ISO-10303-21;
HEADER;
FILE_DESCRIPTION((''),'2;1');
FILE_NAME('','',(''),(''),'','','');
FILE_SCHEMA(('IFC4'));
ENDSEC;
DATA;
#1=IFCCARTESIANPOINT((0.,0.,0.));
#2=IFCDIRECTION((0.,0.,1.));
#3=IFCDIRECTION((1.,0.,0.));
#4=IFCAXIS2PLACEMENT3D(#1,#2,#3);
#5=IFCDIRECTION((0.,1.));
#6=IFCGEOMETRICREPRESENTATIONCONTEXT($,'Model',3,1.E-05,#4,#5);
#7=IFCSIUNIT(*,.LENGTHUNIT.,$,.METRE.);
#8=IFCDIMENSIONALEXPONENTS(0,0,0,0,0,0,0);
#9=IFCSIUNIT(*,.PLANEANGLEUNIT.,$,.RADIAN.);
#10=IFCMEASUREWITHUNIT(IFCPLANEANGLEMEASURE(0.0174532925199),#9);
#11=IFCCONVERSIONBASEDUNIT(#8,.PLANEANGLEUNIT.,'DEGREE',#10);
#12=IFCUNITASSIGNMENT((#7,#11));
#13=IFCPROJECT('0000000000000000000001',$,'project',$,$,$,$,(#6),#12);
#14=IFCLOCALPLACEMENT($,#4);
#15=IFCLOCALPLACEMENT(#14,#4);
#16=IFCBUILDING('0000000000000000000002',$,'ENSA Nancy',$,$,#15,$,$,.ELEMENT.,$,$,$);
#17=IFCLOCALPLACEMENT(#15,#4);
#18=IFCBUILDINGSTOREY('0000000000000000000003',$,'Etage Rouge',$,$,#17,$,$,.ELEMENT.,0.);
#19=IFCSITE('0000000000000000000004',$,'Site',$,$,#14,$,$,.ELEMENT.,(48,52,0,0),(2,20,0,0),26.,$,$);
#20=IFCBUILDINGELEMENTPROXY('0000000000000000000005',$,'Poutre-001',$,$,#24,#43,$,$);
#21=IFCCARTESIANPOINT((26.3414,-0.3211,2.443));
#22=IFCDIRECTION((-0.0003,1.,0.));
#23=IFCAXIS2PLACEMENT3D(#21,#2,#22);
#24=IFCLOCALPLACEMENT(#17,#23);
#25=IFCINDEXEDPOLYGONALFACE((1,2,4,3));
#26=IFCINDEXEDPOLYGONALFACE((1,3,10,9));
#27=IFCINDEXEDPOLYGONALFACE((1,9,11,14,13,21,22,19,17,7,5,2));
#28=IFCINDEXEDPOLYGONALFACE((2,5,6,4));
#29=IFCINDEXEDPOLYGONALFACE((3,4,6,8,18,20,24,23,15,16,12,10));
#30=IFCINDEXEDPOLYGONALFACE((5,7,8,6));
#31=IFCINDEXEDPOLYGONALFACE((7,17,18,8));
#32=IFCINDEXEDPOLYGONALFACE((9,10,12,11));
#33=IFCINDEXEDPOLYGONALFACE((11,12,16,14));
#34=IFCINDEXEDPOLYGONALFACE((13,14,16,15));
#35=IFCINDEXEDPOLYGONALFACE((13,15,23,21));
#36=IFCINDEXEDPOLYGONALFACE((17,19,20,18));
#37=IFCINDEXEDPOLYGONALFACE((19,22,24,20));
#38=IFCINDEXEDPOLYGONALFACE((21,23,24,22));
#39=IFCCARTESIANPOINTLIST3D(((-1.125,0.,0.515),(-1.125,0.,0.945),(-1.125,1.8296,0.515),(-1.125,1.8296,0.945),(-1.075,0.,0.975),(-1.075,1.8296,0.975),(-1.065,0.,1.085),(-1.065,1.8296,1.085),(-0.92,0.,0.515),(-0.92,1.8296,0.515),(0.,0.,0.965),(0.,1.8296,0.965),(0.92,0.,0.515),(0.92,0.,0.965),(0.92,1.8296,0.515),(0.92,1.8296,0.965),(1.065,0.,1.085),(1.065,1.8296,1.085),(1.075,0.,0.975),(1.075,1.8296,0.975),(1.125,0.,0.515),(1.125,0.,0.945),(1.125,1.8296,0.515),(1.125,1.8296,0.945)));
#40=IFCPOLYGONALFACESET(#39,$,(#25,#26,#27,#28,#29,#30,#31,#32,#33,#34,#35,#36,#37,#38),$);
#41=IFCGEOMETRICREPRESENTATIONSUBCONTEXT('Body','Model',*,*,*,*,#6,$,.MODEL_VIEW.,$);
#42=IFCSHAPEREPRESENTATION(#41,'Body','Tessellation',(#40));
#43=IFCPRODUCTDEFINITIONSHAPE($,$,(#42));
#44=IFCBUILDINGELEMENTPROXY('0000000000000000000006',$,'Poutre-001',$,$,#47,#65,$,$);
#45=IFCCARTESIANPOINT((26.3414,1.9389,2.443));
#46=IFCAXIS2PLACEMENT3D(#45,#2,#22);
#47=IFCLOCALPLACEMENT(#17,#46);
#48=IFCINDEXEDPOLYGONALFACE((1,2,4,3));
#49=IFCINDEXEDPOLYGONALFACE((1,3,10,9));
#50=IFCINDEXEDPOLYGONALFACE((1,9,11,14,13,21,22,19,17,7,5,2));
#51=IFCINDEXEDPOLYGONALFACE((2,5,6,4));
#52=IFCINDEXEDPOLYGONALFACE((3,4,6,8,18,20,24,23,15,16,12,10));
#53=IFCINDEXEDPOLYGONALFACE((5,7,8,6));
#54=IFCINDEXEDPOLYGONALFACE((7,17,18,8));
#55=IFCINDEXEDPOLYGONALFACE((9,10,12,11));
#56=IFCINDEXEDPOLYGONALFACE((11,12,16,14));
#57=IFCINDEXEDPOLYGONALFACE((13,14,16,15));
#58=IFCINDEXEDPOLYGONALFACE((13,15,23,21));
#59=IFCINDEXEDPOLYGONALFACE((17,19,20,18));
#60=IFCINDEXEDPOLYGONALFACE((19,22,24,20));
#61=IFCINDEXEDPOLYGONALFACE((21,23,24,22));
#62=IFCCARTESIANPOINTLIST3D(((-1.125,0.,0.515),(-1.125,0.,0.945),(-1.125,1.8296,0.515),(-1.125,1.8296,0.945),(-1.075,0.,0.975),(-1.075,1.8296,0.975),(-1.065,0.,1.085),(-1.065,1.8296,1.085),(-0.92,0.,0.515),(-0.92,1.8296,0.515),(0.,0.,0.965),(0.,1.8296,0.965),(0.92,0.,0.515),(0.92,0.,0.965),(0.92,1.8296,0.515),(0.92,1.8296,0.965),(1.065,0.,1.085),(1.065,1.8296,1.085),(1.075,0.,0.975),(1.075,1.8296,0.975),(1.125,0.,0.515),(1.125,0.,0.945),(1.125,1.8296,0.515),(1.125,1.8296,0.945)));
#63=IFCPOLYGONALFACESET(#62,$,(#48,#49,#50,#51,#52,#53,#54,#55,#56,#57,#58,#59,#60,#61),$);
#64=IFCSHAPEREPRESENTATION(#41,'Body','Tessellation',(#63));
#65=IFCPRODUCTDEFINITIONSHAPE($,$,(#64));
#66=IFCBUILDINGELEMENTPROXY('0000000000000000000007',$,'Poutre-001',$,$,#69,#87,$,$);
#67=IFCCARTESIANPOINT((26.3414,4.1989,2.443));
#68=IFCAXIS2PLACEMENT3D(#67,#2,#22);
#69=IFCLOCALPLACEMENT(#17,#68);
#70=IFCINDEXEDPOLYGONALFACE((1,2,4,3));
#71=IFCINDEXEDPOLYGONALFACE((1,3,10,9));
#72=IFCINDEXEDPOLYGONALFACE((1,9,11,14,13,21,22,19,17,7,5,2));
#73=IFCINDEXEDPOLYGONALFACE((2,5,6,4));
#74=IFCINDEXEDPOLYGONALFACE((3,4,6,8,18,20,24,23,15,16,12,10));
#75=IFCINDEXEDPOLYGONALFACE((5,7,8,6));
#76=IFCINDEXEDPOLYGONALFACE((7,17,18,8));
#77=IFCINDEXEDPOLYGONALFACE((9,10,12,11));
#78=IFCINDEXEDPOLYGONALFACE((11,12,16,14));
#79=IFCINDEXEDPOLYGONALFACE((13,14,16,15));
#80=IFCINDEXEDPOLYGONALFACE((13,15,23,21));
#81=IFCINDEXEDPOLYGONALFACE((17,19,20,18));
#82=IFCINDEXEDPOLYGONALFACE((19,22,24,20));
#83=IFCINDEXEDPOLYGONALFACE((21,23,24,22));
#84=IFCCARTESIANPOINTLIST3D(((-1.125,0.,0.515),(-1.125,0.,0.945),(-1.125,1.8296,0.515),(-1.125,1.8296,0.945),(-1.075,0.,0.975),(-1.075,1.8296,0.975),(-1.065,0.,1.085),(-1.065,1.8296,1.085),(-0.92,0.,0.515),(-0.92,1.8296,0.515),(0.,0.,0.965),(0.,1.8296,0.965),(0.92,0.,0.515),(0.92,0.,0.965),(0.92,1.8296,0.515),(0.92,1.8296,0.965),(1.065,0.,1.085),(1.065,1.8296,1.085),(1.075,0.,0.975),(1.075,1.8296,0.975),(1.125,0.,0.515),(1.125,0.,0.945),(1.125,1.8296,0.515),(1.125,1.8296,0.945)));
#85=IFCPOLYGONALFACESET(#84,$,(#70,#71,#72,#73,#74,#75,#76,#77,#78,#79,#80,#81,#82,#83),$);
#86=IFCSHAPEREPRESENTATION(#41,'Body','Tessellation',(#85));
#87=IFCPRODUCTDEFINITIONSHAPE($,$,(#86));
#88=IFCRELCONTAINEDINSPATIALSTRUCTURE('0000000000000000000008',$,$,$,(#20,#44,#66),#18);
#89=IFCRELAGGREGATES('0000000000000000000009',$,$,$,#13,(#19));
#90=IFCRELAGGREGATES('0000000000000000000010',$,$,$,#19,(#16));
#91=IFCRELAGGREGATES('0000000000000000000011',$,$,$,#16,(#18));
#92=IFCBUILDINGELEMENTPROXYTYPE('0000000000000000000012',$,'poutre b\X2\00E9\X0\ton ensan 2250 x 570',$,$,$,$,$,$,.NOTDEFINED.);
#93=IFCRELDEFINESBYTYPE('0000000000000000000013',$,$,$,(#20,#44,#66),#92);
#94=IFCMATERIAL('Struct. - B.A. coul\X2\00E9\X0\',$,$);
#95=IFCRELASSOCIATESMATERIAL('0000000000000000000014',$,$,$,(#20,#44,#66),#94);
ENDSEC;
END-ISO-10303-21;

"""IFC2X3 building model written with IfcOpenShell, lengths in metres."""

from ifc_helpers import new_model, entity, si_unit, converted_unit, direction, frame, origin_with_axes, place, context, subcontext, project, spatial, polyline, outline, extrude, material, type_object, element, save


model = new_model("IFC2X3")

# Units and contexts
model_context = context("Model", 3, precision=1e-05, world=origin_with_axes(), true_north=direction((0.0, 1.0)))
body_context = subcontext(model_context, "Body", "Model", "MODEL_VIEW")
ifc_project = project(units=[si_unit("LENGTHUNIT", "METRE"), converted_unit("PLANEANGLEUNIT", "DEGREE", entity("IfcPlaneAngleMeasure", 0.0174532925199), si_unit("PLANEANGLEUNIT", "RADIAN"), dimensions=[0, 0, 0, 0, 0, 0, 0])], contexts=[model_context])

# Site, building, storey
site_placement = place(None, origin_with_axes())
site = spatial("IfcSite", under=ifc_project, at=site_placement, Name="Site", CompositionType="ELEMENT", RefLatitude=(48, 52, 0, 0), RefLongitude=(2, 20, 0, 0), RefElevation=26.0)
building_placement = place(site_placement, origin_with_axes())
building = spatial("IfcBuilding", under=site, at=building_placement, Name="ENSA Nancy", CompositionType="ELEMENT")
storey_placement = place(building_placement, origin_with_axes())
storey = spatial("IfcBuildingStorey", under=building, at=storey_placement, Name="Etage Rouge", CompositionType="ELEMENT", Elevation=0.0)

# Building element proxies
ifc_material_1 = material(Name="Struct. - B.A. coulé")
building_element_proxy_type_1 = type_object("IfcBuildingElementProxyType", Name="poutre béton ensan 2250 x 570", PredefinedType="NOTDEFINED")
for number, where, z_axis, x_axis, name in (
    (1, (26.3414, -0.3211, 2.443), (0.0, 0.0, 1.0), (-0.0003, 1.0, 0.0), "Poutre-001"),
    (2, (26.3414, 1.9389, 2.443), (0.0, 0.0, 1.0), (-0.0003, 1.0, 0.0), "Poutre-001"),
    (3, (26.3414, 4.1989, 2.443), (0.0, 0.0, 1.0), (-0.0003, 1.0, 0.0), "Poutre-001"),
):
    element("IfcBuildingElementProxy", number, at=place(storey_placement, frame(where, z_axis=z_axis, x_axis=x_axis)), inside=storey, type_object=building_element_proxy_type_1, material=ifc_material_1, Name=name, context=body_context, shape_type="SweptSolid", body=[
        extrude(outline(polyline([(-1.065, 1.085), (-1.075, 0.975), (-1.125, 0.945), (-1.125, 0.515), (-0.92, 0.515), (0.0, 0.965), (0.92, 0.965), (0.92, 0.515), (1.125, 0.515), (1.125, 0.945), (1.075, 0.975), (1.065, 1.085), (-1.065, 1.085)])), frame((0.0, 1.8296, 0.0), z_axis=(0.0, -1.0, 0.0), x_axis=(1.0, 0.0, 0.0)), (0.0, 0.0, 1.0), 1.8296),
    ])

save(model, "model.ifc")
